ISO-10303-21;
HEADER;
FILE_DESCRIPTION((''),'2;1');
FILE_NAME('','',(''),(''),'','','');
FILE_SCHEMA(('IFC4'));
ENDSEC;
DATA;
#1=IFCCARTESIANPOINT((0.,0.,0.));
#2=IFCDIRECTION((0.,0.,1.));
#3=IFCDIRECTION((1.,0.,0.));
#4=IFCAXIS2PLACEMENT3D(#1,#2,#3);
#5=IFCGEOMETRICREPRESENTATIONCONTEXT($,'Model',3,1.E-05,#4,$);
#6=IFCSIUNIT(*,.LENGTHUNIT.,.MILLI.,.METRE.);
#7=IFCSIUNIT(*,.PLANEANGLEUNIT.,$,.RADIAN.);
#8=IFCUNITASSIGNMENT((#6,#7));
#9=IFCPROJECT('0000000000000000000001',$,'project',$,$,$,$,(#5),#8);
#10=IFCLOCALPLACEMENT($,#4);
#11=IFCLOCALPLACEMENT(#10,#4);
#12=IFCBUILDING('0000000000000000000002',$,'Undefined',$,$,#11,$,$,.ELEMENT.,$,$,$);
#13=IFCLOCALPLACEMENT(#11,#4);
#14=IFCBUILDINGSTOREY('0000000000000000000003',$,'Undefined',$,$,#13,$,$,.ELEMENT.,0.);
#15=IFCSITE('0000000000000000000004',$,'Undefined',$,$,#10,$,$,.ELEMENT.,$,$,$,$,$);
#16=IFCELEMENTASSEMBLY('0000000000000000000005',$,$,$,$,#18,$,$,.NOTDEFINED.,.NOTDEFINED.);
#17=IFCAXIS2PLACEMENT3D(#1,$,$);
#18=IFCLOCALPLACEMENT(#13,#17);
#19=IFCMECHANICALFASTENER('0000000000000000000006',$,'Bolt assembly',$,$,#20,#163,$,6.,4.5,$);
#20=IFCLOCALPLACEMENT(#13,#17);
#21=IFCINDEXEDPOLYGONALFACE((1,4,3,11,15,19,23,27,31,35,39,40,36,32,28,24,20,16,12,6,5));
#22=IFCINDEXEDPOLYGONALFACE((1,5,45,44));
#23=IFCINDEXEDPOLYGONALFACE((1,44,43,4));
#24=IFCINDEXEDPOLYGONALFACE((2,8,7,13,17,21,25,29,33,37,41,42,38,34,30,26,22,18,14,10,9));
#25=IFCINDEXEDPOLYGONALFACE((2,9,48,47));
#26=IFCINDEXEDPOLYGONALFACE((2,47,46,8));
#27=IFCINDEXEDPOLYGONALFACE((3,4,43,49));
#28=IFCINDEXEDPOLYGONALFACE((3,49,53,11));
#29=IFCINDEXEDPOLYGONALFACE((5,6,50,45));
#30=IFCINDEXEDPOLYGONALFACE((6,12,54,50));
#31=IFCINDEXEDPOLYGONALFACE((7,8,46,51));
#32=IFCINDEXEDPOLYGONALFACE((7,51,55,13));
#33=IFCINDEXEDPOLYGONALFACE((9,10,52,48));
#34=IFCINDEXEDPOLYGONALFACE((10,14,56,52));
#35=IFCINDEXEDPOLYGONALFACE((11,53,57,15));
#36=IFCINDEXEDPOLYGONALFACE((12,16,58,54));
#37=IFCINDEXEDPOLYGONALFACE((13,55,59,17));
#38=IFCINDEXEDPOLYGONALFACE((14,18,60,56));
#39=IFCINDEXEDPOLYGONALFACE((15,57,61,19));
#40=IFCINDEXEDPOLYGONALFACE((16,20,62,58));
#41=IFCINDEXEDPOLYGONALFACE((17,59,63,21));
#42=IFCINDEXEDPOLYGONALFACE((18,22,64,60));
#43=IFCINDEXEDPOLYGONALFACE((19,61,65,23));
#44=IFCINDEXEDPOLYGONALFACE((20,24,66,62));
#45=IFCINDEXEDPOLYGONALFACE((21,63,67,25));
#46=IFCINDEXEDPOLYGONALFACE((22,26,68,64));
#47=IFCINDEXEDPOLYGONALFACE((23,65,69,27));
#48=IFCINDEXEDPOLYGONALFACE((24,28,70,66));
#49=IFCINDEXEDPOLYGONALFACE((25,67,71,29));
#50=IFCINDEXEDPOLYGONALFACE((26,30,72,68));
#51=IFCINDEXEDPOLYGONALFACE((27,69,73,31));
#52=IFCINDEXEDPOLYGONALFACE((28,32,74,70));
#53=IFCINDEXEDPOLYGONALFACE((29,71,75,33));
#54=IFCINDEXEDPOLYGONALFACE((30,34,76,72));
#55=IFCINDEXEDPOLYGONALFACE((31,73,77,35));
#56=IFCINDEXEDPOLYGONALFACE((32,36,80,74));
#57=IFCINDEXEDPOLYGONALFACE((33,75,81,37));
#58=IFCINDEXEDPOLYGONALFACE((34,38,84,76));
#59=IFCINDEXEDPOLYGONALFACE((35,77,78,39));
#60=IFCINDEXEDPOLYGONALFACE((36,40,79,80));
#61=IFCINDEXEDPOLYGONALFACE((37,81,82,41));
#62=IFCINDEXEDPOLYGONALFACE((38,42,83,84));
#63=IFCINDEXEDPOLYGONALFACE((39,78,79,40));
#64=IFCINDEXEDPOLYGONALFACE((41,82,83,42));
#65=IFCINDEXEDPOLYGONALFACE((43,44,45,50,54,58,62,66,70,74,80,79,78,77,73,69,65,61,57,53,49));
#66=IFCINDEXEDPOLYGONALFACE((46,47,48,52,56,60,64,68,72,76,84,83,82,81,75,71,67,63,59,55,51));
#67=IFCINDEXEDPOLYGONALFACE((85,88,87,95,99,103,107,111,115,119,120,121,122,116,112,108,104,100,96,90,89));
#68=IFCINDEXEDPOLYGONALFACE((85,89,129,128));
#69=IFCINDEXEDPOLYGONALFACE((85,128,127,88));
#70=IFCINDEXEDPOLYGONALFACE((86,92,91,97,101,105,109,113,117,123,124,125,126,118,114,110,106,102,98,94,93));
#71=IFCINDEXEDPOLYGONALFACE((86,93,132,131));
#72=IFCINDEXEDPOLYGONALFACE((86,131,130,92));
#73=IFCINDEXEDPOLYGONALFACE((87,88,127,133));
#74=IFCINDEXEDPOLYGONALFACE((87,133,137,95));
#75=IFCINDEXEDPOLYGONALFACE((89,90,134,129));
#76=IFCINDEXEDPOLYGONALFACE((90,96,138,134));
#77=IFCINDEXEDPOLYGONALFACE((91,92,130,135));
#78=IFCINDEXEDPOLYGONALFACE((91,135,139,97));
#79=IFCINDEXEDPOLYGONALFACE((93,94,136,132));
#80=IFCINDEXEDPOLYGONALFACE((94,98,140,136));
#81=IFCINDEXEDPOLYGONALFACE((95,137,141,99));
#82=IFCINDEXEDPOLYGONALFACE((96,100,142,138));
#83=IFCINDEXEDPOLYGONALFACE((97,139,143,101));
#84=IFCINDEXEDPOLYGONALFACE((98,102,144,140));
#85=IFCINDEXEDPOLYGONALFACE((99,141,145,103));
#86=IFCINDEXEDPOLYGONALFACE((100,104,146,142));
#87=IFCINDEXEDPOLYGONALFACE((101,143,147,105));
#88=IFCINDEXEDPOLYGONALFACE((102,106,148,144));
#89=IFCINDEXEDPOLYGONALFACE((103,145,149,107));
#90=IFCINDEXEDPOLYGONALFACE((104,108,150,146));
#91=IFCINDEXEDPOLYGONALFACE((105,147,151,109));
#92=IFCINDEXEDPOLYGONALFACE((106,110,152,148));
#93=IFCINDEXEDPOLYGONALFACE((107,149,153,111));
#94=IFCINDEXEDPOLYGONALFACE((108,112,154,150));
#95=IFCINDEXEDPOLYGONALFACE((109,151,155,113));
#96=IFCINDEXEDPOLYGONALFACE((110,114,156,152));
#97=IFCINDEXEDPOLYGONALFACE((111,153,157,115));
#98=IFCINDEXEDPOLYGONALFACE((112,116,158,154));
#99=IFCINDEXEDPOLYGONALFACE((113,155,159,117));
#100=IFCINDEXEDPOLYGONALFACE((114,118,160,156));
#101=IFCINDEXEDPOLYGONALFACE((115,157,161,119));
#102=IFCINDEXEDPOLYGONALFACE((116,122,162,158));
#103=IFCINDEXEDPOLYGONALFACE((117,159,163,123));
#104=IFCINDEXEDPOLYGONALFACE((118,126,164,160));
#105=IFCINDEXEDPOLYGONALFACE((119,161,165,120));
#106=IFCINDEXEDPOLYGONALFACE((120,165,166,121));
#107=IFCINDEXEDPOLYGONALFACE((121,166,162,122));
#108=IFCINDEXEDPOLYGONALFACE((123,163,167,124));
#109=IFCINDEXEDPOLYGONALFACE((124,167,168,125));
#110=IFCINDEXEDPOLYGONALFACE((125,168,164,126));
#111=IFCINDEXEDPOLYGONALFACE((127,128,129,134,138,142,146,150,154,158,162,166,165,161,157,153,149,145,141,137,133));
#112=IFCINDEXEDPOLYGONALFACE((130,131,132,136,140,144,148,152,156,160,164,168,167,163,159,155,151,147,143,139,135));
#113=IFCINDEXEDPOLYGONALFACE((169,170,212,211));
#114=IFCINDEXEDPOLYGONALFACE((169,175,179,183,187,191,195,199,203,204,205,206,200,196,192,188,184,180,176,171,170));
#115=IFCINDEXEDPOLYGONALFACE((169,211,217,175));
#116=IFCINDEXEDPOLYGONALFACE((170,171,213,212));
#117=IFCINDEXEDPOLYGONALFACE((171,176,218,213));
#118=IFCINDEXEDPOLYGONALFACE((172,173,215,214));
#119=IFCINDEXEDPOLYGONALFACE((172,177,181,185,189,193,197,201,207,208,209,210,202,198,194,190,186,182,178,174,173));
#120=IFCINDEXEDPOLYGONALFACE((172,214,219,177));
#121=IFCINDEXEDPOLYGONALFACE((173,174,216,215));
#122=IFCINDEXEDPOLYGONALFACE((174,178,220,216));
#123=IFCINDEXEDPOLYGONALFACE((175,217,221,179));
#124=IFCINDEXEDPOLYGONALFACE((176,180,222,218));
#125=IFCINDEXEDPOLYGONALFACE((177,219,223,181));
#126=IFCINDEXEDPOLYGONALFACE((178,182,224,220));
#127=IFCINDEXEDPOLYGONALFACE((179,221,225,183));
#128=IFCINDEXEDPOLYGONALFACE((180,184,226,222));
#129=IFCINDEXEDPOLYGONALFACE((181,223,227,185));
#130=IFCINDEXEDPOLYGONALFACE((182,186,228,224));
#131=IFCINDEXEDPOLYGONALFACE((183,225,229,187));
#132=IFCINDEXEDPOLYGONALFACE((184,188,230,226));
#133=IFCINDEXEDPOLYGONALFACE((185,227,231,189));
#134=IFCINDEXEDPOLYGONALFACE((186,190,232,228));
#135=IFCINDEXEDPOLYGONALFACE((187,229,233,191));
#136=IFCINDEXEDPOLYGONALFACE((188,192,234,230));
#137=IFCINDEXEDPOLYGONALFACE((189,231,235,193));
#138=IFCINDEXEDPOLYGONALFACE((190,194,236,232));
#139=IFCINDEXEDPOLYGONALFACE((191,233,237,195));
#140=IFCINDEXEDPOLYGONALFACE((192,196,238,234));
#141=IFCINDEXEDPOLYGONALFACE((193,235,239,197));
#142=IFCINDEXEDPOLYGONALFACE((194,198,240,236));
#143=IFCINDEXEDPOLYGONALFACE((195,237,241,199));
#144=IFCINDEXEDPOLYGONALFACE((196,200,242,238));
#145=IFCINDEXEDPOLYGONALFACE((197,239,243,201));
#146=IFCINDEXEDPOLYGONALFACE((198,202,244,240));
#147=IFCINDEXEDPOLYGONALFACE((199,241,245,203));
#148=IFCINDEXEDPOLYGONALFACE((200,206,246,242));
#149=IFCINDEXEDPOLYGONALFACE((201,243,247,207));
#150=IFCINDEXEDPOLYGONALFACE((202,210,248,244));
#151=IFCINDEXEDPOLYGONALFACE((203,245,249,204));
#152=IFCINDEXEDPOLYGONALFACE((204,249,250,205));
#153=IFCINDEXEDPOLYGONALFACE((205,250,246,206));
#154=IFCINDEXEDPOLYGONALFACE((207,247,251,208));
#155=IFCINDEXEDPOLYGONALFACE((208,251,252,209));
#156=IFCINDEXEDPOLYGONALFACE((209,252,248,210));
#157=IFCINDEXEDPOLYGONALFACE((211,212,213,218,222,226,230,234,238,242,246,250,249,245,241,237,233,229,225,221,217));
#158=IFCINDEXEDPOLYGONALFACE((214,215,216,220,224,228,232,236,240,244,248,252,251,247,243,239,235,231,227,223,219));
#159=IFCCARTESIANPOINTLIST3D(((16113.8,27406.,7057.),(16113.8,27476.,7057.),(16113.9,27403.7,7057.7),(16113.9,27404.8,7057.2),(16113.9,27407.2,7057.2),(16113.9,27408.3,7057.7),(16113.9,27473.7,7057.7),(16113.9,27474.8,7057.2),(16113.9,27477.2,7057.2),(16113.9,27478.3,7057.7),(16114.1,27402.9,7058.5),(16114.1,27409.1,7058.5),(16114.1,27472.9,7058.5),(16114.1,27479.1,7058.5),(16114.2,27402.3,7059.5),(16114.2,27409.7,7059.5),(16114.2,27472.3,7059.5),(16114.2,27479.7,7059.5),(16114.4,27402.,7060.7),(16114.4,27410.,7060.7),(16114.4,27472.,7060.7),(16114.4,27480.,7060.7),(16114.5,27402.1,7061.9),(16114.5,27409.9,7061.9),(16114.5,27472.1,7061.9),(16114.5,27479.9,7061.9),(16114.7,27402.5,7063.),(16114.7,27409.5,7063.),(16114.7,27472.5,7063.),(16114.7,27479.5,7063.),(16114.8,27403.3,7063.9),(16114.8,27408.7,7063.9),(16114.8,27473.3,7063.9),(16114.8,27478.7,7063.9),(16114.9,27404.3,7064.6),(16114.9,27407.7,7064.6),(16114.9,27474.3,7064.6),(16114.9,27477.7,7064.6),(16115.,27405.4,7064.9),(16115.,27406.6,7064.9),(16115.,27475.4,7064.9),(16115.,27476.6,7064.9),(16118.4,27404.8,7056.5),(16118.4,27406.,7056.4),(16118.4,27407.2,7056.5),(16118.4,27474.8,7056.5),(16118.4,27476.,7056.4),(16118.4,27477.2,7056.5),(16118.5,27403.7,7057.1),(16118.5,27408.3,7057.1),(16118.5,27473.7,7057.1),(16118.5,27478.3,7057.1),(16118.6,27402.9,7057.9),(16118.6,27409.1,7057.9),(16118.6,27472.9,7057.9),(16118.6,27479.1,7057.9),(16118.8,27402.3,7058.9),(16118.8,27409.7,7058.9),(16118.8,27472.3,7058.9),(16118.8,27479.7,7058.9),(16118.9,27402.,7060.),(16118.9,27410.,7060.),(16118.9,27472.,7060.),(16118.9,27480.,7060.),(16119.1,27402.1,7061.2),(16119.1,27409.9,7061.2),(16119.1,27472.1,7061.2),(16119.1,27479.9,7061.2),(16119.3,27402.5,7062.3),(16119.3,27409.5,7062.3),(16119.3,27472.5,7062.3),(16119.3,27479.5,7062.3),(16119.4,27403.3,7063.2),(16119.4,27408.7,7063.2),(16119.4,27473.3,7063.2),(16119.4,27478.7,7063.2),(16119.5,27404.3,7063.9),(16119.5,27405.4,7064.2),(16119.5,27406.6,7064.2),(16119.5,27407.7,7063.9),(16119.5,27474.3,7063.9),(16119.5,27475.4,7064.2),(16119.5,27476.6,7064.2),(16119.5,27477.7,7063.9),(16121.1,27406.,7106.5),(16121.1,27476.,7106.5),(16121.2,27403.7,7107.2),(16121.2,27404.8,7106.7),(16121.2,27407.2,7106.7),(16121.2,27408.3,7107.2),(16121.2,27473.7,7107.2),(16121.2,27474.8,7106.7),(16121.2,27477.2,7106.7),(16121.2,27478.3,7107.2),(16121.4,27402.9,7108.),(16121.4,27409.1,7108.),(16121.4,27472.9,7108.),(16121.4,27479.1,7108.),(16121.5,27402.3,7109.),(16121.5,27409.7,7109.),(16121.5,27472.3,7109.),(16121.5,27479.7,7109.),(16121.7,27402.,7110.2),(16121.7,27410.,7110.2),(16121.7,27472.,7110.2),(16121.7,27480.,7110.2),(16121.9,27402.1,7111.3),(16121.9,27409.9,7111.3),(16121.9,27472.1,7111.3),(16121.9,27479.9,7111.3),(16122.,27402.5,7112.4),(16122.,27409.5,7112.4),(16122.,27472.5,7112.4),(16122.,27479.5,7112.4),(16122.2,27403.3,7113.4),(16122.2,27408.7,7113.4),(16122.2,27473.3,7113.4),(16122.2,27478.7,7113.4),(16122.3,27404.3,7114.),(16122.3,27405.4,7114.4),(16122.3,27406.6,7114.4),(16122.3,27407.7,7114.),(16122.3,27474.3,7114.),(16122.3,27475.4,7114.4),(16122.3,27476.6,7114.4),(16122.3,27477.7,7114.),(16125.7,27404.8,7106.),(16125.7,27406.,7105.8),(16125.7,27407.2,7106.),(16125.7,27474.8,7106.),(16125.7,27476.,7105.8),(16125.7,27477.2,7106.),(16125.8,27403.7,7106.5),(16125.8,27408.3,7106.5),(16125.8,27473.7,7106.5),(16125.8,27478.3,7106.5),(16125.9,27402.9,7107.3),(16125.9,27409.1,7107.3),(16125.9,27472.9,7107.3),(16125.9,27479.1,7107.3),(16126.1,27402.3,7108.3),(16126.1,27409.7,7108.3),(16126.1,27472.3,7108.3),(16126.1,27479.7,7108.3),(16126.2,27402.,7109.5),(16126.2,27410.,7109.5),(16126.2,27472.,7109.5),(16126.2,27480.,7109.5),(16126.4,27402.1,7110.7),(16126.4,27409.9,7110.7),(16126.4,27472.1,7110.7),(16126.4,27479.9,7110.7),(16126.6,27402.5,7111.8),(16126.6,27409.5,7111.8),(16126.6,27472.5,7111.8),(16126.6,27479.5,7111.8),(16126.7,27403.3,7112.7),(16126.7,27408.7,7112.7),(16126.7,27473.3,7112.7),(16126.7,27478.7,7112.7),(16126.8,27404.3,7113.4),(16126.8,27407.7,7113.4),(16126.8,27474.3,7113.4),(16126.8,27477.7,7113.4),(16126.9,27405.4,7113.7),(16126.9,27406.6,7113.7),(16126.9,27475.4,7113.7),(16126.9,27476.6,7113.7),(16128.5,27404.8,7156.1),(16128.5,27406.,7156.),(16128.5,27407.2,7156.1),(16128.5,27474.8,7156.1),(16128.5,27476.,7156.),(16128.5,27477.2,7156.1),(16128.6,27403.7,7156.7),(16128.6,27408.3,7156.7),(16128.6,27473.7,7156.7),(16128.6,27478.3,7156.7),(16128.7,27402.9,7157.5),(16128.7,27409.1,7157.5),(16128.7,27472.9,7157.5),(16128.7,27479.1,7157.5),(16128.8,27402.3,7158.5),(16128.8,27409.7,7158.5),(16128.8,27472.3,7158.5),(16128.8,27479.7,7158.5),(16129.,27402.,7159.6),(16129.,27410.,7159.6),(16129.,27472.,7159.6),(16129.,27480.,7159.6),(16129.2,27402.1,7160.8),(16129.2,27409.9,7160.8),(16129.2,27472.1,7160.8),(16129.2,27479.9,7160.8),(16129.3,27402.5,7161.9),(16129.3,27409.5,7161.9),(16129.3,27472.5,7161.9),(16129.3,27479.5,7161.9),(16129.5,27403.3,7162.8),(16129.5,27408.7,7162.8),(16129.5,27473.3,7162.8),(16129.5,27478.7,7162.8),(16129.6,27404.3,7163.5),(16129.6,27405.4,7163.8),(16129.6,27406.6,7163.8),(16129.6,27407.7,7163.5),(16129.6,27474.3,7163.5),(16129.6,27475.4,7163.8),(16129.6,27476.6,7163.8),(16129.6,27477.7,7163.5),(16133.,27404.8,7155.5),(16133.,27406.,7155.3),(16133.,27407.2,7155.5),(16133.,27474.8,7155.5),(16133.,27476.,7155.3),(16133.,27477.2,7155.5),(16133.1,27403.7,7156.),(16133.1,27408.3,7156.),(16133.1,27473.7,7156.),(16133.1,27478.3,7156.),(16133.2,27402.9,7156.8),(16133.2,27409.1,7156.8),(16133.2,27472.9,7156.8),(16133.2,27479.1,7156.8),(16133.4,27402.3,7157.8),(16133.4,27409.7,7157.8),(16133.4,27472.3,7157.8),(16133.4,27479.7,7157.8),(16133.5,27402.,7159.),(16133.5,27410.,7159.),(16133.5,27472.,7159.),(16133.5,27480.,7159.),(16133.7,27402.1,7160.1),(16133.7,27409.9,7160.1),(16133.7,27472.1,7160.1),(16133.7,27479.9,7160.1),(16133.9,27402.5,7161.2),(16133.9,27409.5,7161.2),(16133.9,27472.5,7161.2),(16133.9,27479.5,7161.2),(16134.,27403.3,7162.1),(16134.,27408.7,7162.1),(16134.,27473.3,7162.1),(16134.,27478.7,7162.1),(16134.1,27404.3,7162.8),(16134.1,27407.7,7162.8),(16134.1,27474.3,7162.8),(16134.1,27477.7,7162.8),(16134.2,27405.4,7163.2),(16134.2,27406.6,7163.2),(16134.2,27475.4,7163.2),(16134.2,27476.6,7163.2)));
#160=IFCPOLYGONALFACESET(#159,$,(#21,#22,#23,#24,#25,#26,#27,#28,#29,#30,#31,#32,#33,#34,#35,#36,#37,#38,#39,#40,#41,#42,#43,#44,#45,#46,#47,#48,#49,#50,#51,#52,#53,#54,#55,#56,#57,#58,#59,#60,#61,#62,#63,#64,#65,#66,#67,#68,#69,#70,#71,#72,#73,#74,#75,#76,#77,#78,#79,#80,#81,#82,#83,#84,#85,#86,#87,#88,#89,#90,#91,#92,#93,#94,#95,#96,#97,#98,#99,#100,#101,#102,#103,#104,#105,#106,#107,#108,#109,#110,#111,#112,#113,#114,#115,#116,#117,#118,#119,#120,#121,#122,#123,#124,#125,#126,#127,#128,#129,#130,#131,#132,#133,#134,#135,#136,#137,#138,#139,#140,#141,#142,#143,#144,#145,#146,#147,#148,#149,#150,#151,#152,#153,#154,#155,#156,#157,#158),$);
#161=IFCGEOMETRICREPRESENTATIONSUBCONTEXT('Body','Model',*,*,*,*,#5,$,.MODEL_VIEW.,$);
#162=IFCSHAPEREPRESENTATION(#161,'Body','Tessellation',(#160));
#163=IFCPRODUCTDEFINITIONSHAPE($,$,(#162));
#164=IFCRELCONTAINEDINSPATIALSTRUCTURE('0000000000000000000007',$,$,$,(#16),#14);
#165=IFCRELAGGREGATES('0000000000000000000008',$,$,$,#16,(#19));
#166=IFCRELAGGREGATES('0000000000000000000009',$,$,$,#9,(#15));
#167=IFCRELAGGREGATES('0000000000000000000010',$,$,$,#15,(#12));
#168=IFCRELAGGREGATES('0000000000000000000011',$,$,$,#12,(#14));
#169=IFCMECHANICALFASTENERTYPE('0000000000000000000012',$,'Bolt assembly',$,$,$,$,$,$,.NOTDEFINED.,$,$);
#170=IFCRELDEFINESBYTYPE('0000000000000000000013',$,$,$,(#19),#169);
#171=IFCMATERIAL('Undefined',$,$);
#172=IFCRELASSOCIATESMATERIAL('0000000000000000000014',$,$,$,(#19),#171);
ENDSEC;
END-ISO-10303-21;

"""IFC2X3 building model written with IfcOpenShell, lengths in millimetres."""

from ifc_helpers import new_model, si_unit, frame, origin_with_axes, origin_2d_with_axis, place, context, subcontext, project, spatial, circle, extrude, source, transform, mapped, material, type_object, element, aggregate, save


model = new_model("IFC2X3")

# Units and contexts
model_context = context("Model", 3, precision=1e-05, world=origin_with_axes())
body_context = subcontext(model_context, "Body", "Model", "MODEL_VIEW")
ifc_project = project(units=[si_unit("LENGTHUNIT", "METRE", prefix="MILLI"), si_unit("PLANEANGLEUNIT", "RADIAN")], contexts=[model_context])

# Site, building, storey
site_placement = place(None, origin_with_axes())
site = spatial("IfcSite", under=ifc_project, at=site_placement, Name="Undefined", CompositionType="ELEMENT")
building_placement = place(site_placement, origin_with_axes())
building = spatial("IfcBuilding", under=site, at=building_placement, Name="Undefined", CompositionType="ELEMENT")
storey_placement = place(building_placement, origin_with_axes())
storey = spatial("IfcBuildingStorey", under=building, at=storey_placement, Name="Undefined", CompositionType="ELEMENT", Elevation=0.0)

# Element assembly
assembly_1_placement = place(storey_placement, origin_with_axes())
assembly_1 = element("IfcElementAssembly", 1, at=assembly_1_placement, inside=storey, AssemblyPlace="NOTDEFINED", PredefinedType="NOTDEFINED")

# Mechanical fastener
ifc_material_1 = material(Name="Undefined")
mechanical_fastener_type = type_object("IfcMechanicalFastenerType", Name="Bolt assembly")
shared_shape_1 = source(origin_with_axes(), body_context, "Body", "SweptSolid", [
    extrude(circle(Radius=4.0, at=origin_2d_with_axis()), frame((0.0, 0.0, 0.0), z_axis=(0.0, 1.0, 0.0), x_axis=(1.0, 0.0, 0.0)), (0.0, 0.0, 1.0), 4.6),
])
mechanical_fastener_1_placement = place(assembly_1_placement, frame((16133.6, 27441.0, 7159.2), z_axis=(0.0, 1.0, 0.0), x_axis=(-0.146202, 0.0, -0.989255)))
mechanical_fastener_1 = element("IfcMechanicalFastener", 2, at=mechanical_fastener_1_placement, type_object=mechanical_fastener_type, material=ifc_material_1, Name="Bolt assembly", NominalDiameter=6.0, NominalLength=4.5, context=body_context, shape_type="MappedRepresentation", body=[
    mapped(shared_shape_1, transform((0.0, 0.0, 35.0))),
    mapped(shared_shape_1, transform((50.0, 0.0, 35.0))),
    mapped(shared_shape_1, transform((100.0, 0.0, 35.0))),
    mapped(shared_shape_1, transform((0.0, 0.0, -35.0))),
    mapped(shared_shape_1, transform((50.0, 0.0, -35.0))),
    mapped(shared_shape_1, transform((100.0, 0.0, -35.0))),
])

aggregate(assembly_1, [mechanical_fastener_1])

save(model, "model.ifc")
